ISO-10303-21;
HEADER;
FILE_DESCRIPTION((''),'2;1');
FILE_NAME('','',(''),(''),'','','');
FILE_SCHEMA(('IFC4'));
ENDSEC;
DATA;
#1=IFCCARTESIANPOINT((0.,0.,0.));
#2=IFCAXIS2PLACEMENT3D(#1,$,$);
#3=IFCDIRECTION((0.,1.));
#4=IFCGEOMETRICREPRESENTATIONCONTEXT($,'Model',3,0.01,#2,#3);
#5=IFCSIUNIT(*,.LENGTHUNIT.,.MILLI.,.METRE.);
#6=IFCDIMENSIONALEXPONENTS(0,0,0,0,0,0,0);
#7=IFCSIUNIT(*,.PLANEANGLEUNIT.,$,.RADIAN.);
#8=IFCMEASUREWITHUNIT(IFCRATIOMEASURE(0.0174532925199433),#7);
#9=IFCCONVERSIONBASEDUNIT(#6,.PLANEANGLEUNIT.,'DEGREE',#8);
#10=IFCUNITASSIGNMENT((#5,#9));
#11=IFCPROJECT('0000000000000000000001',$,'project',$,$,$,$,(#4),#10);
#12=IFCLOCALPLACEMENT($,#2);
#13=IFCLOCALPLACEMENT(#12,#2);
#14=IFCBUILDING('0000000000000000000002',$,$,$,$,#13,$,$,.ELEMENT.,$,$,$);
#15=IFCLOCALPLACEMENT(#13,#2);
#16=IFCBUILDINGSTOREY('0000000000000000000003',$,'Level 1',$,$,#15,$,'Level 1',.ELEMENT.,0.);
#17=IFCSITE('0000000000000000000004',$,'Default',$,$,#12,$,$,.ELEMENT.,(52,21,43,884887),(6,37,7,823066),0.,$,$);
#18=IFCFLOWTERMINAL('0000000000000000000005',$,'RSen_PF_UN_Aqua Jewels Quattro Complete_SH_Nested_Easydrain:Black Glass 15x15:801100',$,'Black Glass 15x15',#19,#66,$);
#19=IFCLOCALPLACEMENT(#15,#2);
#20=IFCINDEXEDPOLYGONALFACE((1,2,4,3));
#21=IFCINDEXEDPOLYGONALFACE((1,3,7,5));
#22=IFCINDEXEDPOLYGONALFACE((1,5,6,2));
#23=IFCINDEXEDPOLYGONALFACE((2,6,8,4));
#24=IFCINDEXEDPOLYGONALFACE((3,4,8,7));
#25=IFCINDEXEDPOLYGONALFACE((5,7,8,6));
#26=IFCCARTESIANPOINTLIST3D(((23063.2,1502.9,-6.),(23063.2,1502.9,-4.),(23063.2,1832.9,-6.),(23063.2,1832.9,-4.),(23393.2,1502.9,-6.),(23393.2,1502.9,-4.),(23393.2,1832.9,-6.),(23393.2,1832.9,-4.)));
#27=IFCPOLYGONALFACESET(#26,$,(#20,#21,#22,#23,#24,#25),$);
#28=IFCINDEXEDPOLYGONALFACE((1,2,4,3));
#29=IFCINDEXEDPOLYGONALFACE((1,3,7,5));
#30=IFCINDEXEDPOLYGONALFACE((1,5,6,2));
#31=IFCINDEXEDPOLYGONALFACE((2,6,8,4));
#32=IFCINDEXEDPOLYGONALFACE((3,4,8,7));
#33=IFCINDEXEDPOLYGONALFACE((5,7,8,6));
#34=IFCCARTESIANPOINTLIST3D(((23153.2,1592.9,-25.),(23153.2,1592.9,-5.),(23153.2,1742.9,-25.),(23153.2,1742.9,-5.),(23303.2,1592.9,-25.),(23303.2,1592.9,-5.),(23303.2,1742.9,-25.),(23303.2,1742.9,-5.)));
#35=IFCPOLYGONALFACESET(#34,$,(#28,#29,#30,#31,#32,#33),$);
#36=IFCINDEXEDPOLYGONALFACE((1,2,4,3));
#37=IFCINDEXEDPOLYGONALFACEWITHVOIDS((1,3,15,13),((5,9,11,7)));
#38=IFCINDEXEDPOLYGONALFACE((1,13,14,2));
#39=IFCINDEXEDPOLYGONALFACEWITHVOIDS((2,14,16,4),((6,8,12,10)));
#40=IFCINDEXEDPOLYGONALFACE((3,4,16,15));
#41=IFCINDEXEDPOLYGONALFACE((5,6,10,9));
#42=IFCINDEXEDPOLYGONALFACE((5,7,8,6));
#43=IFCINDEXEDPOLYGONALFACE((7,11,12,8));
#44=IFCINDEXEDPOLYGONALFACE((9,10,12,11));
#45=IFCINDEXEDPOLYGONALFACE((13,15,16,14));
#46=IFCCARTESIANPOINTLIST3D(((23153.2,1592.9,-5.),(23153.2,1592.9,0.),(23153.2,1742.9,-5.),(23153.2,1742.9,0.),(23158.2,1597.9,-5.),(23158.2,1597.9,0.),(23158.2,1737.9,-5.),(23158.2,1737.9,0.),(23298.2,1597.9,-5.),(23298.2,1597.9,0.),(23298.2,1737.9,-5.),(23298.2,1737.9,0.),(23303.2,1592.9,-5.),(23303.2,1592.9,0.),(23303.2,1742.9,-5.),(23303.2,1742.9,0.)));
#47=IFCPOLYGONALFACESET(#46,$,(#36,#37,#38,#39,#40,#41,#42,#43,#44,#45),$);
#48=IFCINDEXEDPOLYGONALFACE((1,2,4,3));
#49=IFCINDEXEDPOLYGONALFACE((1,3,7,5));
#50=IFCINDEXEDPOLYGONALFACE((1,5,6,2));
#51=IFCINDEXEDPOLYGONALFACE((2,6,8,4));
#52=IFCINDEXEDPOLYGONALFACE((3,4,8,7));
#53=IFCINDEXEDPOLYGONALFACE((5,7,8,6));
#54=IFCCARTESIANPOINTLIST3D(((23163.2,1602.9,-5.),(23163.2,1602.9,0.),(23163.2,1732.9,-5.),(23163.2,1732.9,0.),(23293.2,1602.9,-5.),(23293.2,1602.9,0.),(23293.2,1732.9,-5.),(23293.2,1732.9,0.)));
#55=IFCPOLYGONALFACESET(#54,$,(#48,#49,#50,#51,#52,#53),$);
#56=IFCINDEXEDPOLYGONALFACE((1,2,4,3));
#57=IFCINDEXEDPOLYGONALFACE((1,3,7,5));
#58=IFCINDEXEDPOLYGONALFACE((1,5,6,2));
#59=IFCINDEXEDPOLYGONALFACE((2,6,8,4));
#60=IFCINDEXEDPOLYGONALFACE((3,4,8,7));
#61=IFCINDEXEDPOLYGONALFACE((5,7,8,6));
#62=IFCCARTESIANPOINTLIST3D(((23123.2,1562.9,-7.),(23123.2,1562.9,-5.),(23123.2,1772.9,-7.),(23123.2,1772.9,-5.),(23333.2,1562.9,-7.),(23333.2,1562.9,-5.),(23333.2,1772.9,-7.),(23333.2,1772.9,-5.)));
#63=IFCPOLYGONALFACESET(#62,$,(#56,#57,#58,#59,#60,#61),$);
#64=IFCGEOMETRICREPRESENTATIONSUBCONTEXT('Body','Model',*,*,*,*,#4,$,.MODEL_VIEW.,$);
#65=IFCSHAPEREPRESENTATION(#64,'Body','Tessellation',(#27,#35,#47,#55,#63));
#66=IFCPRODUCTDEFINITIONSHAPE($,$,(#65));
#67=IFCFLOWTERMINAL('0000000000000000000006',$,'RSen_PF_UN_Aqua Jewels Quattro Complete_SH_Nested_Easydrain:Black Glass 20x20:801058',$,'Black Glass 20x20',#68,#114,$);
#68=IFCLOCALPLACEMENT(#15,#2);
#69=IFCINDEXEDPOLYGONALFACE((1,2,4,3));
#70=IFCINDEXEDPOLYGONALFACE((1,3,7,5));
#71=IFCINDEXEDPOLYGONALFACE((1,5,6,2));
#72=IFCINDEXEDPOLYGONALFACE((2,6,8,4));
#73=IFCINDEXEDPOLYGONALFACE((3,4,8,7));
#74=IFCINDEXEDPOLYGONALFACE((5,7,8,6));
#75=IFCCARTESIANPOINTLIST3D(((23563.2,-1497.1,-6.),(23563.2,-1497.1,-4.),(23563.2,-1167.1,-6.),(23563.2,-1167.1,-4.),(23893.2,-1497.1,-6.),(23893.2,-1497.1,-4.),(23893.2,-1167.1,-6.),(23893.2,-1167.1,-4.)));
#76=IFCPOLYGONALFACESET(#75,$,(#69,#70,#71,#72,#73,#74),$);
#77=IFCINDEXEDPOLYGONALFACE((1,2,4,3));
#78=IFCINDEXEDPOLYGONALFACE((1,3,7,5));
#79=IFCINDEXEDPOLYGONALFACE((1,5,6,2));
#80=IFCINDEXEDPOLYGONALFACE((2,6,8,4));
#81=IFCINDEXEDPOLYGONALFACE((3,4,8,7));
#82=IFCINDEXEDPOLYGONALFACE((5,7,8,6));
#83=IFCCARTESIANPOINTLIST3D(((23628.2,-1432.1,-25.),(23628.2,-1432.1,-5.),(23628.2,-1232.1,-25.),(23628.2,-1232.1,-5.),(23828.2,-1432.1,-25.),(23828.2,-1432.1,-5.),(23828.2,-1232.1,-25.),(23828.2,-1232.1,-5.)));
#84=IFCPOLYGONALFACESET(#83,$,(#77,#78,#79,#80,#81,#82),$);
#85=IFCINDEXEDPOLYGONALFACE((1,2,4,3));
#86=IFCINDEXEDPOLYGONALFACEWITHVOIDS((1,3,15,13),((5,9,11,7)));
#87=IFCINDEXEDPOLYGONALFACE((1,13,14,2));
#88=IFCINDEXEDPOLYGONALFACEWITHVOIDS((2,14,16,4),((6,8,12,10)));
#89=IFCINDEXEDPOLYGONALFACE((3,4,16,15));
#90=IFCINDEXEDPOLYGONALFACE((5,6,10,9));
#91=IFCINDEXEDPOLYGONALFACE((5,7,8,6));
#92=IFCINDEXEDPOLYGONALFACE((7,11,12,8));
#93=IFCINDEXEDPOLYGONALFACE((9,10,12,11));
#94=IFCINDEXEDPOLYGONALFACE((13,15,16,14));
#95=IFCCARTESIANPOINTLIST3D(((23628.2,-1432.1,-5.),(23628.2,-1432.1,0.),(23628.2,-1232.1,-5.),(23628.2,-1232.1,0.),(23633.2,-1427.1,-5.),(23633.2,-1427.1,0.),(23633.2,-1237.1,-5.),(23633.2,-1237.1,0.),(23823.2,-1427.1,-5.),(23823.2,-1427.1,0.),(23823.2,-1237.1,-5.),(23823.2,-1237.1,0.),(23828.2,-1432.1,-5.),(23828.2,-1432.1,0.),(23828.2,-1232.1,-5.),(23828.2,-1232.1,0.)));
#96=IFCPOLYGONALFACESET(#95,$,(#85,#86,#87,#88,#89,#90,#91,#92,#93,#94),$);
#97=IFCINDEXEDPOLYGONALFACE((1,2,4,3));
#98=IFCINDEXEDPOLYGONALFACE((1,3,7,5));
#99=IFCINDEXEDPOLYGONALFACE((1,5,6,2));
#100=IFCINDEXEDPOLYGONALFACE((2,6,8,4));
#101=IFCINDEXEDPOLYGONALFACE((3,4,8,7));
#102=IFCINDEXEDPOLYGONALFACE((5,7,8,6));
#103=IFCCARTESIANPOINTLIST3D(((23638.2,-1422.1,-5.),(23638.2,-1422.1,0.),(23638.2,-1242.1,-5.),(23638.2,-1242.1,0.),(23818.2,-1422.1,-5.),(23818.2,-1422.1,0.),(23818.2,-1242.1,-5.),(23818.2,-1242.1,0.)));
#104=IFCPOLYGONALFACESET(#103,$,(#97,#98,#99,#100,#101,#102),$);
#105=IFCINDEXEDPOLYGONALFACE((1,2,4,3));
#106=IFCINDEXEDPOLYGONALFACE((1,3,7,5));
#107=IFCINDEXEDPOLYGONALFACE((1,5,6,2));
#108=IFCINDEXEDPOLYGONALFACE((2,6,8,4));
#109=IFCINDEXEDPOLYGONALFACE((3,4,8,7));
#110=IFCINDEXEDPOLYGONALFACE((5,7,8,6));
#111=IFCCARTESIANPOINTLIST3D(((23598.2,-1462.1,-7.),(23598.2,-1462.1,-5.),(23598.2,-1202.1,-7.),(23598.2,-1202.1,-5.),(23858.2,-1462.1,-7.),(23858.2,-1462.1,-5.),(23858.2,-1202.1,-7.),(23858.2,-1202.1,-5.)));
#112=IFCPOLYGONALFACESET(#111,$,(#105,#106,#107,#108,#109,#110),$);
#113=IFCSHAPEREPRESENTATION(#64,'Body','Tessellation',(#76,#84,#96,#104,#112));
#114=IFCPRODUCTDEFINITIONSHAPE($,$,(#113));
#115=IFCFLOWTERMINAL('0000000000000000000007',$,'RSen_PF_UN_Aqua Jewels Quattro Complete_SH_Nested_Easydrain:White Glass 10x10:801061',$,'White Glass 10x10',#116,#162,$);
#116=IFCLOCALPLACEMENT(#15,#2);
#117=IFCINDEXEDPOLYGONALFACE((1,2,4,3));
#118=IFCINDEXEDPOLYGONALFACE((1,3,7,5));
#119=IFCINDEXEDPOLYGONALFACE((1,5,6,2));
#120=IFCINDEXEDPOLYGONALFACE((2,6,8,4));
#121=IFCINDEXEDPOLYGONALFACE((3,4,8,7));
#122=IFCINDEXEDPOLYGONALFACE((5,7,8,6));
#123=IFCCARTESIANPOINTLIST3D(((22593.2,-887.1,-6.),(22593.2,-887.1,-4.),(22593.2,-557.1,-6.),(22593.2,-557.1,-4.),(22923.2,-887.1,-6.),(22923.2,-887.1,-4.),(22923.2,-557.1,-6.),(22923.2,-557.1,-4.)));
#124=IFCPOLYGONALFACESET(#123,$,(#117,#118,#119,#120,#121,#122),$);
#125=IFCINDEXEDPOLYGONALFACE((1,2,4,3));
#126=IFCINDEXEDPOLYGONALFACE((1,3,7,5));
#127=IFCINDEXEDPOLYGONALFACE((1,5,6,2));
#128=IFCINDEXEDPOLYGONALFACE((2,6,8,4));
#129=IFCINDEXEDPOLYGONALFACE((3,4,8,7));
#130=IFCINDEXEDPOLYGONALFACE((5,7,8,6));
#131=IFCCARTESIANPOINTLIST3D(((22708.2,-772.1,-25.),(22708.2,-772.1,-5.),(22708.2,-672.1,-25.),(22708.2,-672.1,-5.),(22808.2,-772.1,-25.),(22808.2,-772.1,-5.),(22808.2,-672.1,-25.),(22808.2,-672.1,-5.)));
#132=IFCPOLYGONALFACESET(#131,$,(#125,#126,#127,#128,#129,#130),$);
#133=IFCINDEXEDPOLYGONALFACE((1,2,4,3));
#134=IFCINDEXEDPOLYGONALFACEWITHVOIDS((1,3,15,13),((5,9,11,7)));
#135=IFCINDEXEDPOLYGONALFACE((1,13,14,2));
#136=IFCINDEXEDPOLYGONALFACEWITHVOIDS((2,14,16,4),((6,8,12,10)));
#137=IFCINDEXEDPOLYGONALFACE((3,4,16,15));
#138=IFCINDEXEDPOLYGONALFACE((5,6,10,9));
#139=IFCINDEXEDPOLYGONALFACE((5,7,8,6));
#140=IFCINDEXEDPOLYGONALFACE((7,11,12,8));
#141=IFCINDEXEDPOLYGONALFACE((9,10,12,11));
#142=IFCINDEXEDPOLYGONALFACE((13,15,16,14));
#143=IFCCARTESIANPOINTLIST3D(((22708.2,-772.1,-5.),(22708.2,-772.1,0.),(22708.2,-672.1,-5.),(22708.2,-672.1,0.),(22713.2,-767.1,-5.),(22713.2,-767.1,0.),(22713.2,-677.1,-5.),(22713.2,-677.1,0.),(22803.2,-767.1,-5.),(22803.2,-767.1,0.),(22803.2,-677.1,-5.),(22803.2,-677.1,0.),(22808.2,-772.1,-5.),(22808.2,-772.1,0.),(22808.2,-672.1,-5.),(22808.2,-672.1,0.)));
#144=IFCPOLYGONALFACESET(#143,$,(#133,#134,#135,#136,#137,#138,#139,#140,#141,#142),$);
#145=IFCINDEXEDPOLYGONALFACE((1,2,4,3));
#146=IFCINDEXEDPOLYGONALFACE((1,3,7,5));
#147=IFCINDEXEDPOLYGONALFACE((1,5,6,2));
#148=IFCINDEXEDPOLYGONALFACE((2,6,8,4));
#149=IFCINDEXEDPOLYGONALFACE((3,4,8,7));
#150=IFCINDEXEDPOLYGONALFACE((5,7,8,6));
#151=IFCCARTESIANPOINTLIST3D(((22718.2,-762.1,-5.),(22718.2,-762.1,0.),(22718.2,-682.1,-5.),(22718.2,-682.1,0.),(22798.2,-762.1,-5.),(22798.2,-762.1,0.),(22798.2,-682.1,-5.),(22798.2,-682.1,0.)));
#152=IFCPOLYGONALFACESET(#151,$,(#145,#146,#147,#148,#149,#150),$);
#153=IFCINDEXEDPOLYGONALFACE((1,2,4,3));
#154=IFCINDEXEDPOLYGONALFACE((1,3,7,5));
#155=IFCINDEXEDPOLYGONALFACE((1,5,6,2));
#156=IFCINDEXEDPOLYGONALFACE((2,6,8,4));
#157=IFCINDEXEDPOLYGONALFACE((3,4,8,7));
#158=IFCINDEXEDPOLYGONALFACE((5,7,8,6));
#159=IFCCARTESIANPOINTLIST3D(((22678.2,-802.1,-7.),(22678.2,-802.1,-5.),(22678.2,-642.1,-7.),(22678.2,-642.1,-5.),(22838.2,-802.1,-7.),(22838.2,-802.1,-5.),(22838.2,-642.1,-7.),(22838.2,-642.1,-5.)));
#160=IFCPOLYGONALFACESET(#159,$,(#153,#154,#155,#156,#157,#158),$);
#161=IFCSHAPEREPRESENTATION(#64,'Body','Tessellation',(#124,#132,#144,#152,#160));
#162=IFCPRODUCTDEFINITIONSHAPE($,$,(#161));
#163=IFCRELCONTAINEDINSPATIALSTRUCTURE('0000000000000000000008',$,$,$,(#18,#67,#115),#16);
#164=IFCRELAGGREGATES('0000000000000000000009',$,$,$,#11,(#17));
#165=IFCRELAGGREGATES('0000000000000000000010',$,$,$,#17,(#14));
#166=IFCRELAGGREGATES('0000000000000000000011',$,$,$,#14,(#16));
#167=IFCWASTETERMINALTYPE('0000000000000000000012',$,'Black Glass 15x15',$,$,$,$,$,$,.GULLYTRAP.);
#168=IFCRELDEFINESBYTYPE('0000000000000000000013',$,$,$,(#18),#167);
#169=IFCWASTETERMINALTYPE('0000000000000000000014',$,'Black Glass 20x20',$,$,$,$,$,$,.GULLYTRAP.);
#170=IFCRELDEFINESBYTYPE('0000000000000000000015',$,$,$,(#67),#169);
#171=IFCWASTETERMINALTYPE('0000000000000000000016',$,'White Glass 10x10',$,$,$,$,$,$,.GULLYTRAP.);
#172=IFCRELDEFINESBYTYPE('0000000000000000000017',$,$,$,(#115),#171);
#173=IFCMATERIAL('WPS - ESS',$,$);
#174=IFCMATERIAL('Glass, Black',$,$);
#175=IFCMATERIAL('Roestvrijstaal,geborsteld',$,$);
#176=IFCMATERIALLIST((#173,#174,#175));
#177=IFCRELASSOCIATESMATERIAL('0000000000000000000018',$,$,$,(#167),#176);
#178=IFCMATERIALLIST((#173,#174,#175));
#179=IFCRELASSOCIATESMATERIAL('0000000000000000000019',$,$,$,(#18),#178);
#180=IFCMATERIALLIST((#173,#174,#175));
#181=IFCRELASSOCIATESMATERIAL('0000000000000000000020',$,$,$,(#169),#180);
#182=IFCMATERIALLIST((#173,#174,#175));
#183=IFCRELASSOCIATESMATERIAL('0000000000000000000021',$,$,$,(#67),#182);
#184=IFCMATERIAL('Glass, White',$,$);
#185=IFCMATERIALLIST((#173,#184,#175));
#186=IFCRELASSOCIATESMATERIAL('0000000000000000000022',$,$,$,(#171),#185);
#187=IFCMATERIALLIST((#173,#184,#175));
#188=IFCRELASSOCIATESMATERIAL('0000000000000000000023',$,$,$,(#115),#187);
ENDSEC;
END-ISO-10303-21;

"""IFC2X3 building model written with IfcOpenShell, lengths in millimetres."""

from ifc_helpers import new_model, entity, si_unit, converted_unit, direction, frame, frame_2d, origin, origin_2d_with_axis, place, context, subcontext, project, spatial, polyline, rectangle, outline, extrude, source, transform, mapped, material, material_list, type_object, type_shapes, element, save


model = new_model("IFC2X3")

# Units and contexts
model_context = context("Model", 3, precision=0.01, world=origin(), true_north=direction((0.0, 1.0)))
body_context = subcontext(model_context, "Body", "Model", "MODEL_VIEW")
ifc_project = project(units=[si_unit("LENGTHUNIT", "METRE", prefix="MILLI"), converted_unit("PLANEANGLEUNIT", "DEGREE", entity("IfcRatioMeasure", 0.0174532925199433), si_unit("PLANEANGLEUNIT", "RADIAN"), dimensions=[0, 0, 0, 0, 0, 0, 0])], contexts=[model_context])

# Site, building, storey
site_placement = place(None, origin())
site = spatial("IfcSite", under=ifc_project, at=site_placement, Name="Default", CompositionType="ELEMENT", RefLatitude=(52, 21, 43, 884887), RefLongitude=(6, 37, 7, 823066), RefElevation=0.0)
building_placement = place(site_placement, origin())
building = spatial("IfcBuilding", under=site, at=building_placement, CompositionType="ELEMENT")
storey_placement = place(building_placement, origin())
storey = spatial("IfcBuildingStorey", under=building, at=storey_placement, Name="Level 1", LongName="Level 1", CompositionType="ELEMENT", Elevation=0.0)

# Flow terminals
ifc_material_1 = material(Name="WPS - ESS")
ifc_material_2 = material(Name="Roestvrijstaal,geborsteld")
ifc_material_3 = material(Name="Glass, Black")
ifc_material_list_1 = material_list([ifc_material_1, ifc_material_3, ifc_material_2])
waste_terminal_type_1 = type_object("IfcWasteTerminalType", Name="Black Glass 15x15", PredefinedType="GULLYTRAP", material=ifc_material_list_1)
shared_shape_1 = source(origin(), body_context, "Body", "SweptSolid", [
    extrude(rectangle(XDim=330.0, YDim=330.0, at=origin_2d_with_axis()), frame((5.0, -10.0, -6.0), z_axis=(0.0, 0.0, 1.0), x_axis=(-1.0, 0.0, 0.0)), (0.0, 0.0, 1.0), 2.0),
    extrude(rectangle(XDim=150.0, YDim=150.0, at=origin_2d_with_axis()), frame((5.0, -10.0, -25.0), z_axis=(0.0, 0.0, 1.0), x_axis=(-1.0, 0.0, 0.0)), (0.0, 0.0, 1.0), 20.0),
    extrude(outline(polyline([(-75.0, -75.0), (75.0, -75.0), (75.0, 75.0), (-75.0, 75.0), (-75.0, -75.0)]), holes=[polyline([(-70.0, -70.0), (-70.0, 70.0), (70.0, 70.0), (70.0, -70.0), (-70.0, -70.0)])]), frame((5.0, -10.0, -5.0), z_axis=(0.0, 0.0, 1.0), x_axis=(-1.0, 0.0, 0.0)), (0.0, 0.0, 1.0), 5.0),
    extrude(rectangle(XDim=130.0, YDim=130.0, at=frame_2d((0.0, 0.0), x_axis=(1.0, 0.0))), frame((5.0, -10.0, -5.0), z_axis=(0.0, 0.0, 1.0), x_axis=(-1.0, 0.0, 0.0)), (0.0, 0.0, 1.0), 5.0),
    extrude(rectangle(XDim=210.0, YDim=210.0, at=origin_2d_with_axis()), frame((5.0, -10.0, -7.0), z_axis=(0.0, 0.0, 1.0), x_axis=(-1.0, 0.0, 0.0)), (0.0, 0.0, 1.0), 2.0),
])
type_shapes(waste_terminal_type_1, [shared_shape_1])
ifc_material_list_2 = material_list([ifc_material_1, ifc_material_3, ifc_material_2])
flow_terminal_1_placement = place(storey_placement, frame((23223.2, 1677.9, 0.0)))
element("IfcFlowTerminal", 1, at=flow_terminal_1_placement, inside=storey, type_object=waste_terminal_type_1, material=ifc_material_list_2, Name="RSen_PF_UN_Aqua Jewels Quattro Complete_SH_Nested_Easydrain:Black Glass 15x15:801100", ObjectType="Black Glass 15x15", context=body_context, shape_type="MappedRepresentation", body=[
    mapped(shared_shape_1, transform((0.0, 0.0, 0.0), scale=1.0)),
])
ifc_material_list_3 = material_list([ifc_material_1, ifc_material_3, ifc_material_2])
ifc_material_list_4 = material_list([ifc_material_1, ifc_material_3, ifc_material_2])
waste_terminal_type_2 = type_object("IfcWasteTerminalType", Name="Black Glass 20x20", PredefinedType="GULLYTRAP", material=ifc_material_list_4)
shared_shape_2 = source(origin(), body_context, "Body", "SweptSolid", [
    extrude(rectangle(XDim=330.0, YDim=330.0, at=origin_2d_with_axis()), frame((5.0, -10.0, -6.0), z_axis=(0.0, 0.0, 1.0), x_axis=(-1.0, 0.0, 0.0)), (0.0, 0.0, 1.0), 2.0),
    extrude(rectangle(XDim=200.0, YDim=200.0, at=origin_2d_with_axis()), frame((5.0, -10.0, -25.0), z_axis=(0.0, 0.0, 1.0), x_axis=(-1.0, 0.0, 0.0)), (0.0, 0.0, 1.0), 20.0),
    extrude(outline(polyline([(-100.0, -100.0), (100.0, -100.0), (100.0, 100.0), (-100.0, 100.0), (-100.0, -100.0)]), holes=[polyline([(-95.0, -95.0), (-95.0, 95.0), (95.0, 95.0), (95.0, -95.0), (-95.0, -95.0)])]), frame((5.0, -10.0, -5.0), z_axis=(0.0, 0.0, 1.0), x_axis=(-1.0, 0.0, 0.0)), (0.0, 0.0, 1.0), 5.0),
    extrude(rectangle(XDim=180.0, YDim=180.0, at=frame_2d((0.0, 0.0), x_axis=(1.0, 0.0))), frame((5.0, -10.0, -5.0), z_axis=(0.0, 0.0, 1.0), x_axis=(-1.0, 0.0, 0.0)), (0.0, 0.0, 1.0), 5.0),
    extrude(rectangle(XDim=260.0, YDim=260.0, at=origin_2d_with_axis()), frame((5.0, -10.0, -7.0), z_axis=(0.0, 0.0, 1.0), x_axis=(-1.0, 0.0, 0.0)), (0.0, 0.0, 1.0), 2.0),
])
type_shapes(waste_terminal_type_2, [shared_shape_2])
flow_terminal_2_placement = place(storey_placement, frame((23723.2, -1322.1, 0.0)))
element("IfcFlowTerminal", 2, at=flow_terminal_2_placement, inside=storey, type_object=waste_terminal_type_2, material=ifc_material_list_3, Name="RSen_PF_UN_Aqua Jewels Quattro Complete_SH_Nested_Easydrain:Black Glass 20x20:801058", ObjectType="Black Glass 20x20", context=body_context, shape_type="MappedRepresentation", body=[
    mapped(shared_shape_2, transform((0.0, 0.0, 0.0), scale=1.0)),
])
ifc_material_4 = material(Name="Glass, White")
ifc_material_list_5 = material_list([ifc_material_1, ifc_material_4, ifc_material_2])
ifc_material_list_6 = material_list([ifc_material_1, ifc_material_4, ifc_material_2])
waste_terminal_type_3 = type_object("IfcWasteTerminalType", Name="White Glass 10x10", PredefinedType="GULLYTRAP", material=ifc_material_list_6)
shared_shape_3 = source(origin(), body_context, "Body", "SweptSolid", [
    extrude(rectangle(XDim=330.0, YDim=330.0, at=origin_2d_with_axis()), frame((0.0, 0.0, -6.0), z_axis=(0.0, 0.0, 1.0), x_axis=(-1.0, 0.0, 0.0)), (0.0, 0.0, 1.0), 2.0),
    extrude(rectangle(XDim=100.0, YDim=100.0, at=origin_2d_with_axis()), frame((0.0, 0.0, -25.0), z_axis=(0.0, 0.0, 1.0), x_axis=(-1.0, 0.0, 0.0)), (0.0, 0.0, 1.0), 20.0),
    extrude(outline(polyline([(-50.0, -50.0), (50.0, -50.0), (50.0, 50.0), (-50.0, 50.0), (-50.0, -50.0)]), holes=[polyline([(-45.0, -45.0), (-45.0, 45.0), (45.0, 45.0), (45.0, -45.0), (-45.0, -45.0)])]), frame((0.0, 0.0, -5.0), z_axis=(0.0, 0.0, 1.0), x_axis=(-1.0, 0.0, 0.0)), (0.0, 0.0, 1.0), 5.0),
    extrude(rectangle(XDim=80.0, YDim=80.0, at=origin_2d_with_axis()), frame((0.0, 0.0, -5.0), z_axis=(0.0, 0.0, 1.0), x_axis=(-1.0, 0.0, 0.0)), (0.0, 0.0, 1.0), 5.0),
    extrude(rectangle(XDim=160.0, YDim=160.0, at=origin_2d_with_axis()), frame((0.0, 0.0, -7.0), z_axis=(0.0, 0.0, 1.0), x_axis=(-1.0, 0.0, 0.0)), (0.0, 0.0, 1.0), 2.0),
])
type_shapes(waste_terminal_type_3, [shared_shape_3])
flow_terminal_3_placement = place(storey_placement, frame((22758.2, -722.1, 0.0)))
element("IfcFlowTerminal", 3, at=flow_terminal_3_placement, inside=storey, type_object=waste_terminal_type_3, material=ifc_material_list_5, Name="RSen_PF_UN_Aqua Jewels Quattro Complete_SH_Nested_Easydrain:White Glass 10x10:801061", ObjectType="White Glass 10x10", context=body_context, shape_type="MappedRepresentation", body=[
    mapped(shared_shape_3, transform((0.0, 0.0, 0.0), scale=1.0)),
])

save(model, "model.ifc")
